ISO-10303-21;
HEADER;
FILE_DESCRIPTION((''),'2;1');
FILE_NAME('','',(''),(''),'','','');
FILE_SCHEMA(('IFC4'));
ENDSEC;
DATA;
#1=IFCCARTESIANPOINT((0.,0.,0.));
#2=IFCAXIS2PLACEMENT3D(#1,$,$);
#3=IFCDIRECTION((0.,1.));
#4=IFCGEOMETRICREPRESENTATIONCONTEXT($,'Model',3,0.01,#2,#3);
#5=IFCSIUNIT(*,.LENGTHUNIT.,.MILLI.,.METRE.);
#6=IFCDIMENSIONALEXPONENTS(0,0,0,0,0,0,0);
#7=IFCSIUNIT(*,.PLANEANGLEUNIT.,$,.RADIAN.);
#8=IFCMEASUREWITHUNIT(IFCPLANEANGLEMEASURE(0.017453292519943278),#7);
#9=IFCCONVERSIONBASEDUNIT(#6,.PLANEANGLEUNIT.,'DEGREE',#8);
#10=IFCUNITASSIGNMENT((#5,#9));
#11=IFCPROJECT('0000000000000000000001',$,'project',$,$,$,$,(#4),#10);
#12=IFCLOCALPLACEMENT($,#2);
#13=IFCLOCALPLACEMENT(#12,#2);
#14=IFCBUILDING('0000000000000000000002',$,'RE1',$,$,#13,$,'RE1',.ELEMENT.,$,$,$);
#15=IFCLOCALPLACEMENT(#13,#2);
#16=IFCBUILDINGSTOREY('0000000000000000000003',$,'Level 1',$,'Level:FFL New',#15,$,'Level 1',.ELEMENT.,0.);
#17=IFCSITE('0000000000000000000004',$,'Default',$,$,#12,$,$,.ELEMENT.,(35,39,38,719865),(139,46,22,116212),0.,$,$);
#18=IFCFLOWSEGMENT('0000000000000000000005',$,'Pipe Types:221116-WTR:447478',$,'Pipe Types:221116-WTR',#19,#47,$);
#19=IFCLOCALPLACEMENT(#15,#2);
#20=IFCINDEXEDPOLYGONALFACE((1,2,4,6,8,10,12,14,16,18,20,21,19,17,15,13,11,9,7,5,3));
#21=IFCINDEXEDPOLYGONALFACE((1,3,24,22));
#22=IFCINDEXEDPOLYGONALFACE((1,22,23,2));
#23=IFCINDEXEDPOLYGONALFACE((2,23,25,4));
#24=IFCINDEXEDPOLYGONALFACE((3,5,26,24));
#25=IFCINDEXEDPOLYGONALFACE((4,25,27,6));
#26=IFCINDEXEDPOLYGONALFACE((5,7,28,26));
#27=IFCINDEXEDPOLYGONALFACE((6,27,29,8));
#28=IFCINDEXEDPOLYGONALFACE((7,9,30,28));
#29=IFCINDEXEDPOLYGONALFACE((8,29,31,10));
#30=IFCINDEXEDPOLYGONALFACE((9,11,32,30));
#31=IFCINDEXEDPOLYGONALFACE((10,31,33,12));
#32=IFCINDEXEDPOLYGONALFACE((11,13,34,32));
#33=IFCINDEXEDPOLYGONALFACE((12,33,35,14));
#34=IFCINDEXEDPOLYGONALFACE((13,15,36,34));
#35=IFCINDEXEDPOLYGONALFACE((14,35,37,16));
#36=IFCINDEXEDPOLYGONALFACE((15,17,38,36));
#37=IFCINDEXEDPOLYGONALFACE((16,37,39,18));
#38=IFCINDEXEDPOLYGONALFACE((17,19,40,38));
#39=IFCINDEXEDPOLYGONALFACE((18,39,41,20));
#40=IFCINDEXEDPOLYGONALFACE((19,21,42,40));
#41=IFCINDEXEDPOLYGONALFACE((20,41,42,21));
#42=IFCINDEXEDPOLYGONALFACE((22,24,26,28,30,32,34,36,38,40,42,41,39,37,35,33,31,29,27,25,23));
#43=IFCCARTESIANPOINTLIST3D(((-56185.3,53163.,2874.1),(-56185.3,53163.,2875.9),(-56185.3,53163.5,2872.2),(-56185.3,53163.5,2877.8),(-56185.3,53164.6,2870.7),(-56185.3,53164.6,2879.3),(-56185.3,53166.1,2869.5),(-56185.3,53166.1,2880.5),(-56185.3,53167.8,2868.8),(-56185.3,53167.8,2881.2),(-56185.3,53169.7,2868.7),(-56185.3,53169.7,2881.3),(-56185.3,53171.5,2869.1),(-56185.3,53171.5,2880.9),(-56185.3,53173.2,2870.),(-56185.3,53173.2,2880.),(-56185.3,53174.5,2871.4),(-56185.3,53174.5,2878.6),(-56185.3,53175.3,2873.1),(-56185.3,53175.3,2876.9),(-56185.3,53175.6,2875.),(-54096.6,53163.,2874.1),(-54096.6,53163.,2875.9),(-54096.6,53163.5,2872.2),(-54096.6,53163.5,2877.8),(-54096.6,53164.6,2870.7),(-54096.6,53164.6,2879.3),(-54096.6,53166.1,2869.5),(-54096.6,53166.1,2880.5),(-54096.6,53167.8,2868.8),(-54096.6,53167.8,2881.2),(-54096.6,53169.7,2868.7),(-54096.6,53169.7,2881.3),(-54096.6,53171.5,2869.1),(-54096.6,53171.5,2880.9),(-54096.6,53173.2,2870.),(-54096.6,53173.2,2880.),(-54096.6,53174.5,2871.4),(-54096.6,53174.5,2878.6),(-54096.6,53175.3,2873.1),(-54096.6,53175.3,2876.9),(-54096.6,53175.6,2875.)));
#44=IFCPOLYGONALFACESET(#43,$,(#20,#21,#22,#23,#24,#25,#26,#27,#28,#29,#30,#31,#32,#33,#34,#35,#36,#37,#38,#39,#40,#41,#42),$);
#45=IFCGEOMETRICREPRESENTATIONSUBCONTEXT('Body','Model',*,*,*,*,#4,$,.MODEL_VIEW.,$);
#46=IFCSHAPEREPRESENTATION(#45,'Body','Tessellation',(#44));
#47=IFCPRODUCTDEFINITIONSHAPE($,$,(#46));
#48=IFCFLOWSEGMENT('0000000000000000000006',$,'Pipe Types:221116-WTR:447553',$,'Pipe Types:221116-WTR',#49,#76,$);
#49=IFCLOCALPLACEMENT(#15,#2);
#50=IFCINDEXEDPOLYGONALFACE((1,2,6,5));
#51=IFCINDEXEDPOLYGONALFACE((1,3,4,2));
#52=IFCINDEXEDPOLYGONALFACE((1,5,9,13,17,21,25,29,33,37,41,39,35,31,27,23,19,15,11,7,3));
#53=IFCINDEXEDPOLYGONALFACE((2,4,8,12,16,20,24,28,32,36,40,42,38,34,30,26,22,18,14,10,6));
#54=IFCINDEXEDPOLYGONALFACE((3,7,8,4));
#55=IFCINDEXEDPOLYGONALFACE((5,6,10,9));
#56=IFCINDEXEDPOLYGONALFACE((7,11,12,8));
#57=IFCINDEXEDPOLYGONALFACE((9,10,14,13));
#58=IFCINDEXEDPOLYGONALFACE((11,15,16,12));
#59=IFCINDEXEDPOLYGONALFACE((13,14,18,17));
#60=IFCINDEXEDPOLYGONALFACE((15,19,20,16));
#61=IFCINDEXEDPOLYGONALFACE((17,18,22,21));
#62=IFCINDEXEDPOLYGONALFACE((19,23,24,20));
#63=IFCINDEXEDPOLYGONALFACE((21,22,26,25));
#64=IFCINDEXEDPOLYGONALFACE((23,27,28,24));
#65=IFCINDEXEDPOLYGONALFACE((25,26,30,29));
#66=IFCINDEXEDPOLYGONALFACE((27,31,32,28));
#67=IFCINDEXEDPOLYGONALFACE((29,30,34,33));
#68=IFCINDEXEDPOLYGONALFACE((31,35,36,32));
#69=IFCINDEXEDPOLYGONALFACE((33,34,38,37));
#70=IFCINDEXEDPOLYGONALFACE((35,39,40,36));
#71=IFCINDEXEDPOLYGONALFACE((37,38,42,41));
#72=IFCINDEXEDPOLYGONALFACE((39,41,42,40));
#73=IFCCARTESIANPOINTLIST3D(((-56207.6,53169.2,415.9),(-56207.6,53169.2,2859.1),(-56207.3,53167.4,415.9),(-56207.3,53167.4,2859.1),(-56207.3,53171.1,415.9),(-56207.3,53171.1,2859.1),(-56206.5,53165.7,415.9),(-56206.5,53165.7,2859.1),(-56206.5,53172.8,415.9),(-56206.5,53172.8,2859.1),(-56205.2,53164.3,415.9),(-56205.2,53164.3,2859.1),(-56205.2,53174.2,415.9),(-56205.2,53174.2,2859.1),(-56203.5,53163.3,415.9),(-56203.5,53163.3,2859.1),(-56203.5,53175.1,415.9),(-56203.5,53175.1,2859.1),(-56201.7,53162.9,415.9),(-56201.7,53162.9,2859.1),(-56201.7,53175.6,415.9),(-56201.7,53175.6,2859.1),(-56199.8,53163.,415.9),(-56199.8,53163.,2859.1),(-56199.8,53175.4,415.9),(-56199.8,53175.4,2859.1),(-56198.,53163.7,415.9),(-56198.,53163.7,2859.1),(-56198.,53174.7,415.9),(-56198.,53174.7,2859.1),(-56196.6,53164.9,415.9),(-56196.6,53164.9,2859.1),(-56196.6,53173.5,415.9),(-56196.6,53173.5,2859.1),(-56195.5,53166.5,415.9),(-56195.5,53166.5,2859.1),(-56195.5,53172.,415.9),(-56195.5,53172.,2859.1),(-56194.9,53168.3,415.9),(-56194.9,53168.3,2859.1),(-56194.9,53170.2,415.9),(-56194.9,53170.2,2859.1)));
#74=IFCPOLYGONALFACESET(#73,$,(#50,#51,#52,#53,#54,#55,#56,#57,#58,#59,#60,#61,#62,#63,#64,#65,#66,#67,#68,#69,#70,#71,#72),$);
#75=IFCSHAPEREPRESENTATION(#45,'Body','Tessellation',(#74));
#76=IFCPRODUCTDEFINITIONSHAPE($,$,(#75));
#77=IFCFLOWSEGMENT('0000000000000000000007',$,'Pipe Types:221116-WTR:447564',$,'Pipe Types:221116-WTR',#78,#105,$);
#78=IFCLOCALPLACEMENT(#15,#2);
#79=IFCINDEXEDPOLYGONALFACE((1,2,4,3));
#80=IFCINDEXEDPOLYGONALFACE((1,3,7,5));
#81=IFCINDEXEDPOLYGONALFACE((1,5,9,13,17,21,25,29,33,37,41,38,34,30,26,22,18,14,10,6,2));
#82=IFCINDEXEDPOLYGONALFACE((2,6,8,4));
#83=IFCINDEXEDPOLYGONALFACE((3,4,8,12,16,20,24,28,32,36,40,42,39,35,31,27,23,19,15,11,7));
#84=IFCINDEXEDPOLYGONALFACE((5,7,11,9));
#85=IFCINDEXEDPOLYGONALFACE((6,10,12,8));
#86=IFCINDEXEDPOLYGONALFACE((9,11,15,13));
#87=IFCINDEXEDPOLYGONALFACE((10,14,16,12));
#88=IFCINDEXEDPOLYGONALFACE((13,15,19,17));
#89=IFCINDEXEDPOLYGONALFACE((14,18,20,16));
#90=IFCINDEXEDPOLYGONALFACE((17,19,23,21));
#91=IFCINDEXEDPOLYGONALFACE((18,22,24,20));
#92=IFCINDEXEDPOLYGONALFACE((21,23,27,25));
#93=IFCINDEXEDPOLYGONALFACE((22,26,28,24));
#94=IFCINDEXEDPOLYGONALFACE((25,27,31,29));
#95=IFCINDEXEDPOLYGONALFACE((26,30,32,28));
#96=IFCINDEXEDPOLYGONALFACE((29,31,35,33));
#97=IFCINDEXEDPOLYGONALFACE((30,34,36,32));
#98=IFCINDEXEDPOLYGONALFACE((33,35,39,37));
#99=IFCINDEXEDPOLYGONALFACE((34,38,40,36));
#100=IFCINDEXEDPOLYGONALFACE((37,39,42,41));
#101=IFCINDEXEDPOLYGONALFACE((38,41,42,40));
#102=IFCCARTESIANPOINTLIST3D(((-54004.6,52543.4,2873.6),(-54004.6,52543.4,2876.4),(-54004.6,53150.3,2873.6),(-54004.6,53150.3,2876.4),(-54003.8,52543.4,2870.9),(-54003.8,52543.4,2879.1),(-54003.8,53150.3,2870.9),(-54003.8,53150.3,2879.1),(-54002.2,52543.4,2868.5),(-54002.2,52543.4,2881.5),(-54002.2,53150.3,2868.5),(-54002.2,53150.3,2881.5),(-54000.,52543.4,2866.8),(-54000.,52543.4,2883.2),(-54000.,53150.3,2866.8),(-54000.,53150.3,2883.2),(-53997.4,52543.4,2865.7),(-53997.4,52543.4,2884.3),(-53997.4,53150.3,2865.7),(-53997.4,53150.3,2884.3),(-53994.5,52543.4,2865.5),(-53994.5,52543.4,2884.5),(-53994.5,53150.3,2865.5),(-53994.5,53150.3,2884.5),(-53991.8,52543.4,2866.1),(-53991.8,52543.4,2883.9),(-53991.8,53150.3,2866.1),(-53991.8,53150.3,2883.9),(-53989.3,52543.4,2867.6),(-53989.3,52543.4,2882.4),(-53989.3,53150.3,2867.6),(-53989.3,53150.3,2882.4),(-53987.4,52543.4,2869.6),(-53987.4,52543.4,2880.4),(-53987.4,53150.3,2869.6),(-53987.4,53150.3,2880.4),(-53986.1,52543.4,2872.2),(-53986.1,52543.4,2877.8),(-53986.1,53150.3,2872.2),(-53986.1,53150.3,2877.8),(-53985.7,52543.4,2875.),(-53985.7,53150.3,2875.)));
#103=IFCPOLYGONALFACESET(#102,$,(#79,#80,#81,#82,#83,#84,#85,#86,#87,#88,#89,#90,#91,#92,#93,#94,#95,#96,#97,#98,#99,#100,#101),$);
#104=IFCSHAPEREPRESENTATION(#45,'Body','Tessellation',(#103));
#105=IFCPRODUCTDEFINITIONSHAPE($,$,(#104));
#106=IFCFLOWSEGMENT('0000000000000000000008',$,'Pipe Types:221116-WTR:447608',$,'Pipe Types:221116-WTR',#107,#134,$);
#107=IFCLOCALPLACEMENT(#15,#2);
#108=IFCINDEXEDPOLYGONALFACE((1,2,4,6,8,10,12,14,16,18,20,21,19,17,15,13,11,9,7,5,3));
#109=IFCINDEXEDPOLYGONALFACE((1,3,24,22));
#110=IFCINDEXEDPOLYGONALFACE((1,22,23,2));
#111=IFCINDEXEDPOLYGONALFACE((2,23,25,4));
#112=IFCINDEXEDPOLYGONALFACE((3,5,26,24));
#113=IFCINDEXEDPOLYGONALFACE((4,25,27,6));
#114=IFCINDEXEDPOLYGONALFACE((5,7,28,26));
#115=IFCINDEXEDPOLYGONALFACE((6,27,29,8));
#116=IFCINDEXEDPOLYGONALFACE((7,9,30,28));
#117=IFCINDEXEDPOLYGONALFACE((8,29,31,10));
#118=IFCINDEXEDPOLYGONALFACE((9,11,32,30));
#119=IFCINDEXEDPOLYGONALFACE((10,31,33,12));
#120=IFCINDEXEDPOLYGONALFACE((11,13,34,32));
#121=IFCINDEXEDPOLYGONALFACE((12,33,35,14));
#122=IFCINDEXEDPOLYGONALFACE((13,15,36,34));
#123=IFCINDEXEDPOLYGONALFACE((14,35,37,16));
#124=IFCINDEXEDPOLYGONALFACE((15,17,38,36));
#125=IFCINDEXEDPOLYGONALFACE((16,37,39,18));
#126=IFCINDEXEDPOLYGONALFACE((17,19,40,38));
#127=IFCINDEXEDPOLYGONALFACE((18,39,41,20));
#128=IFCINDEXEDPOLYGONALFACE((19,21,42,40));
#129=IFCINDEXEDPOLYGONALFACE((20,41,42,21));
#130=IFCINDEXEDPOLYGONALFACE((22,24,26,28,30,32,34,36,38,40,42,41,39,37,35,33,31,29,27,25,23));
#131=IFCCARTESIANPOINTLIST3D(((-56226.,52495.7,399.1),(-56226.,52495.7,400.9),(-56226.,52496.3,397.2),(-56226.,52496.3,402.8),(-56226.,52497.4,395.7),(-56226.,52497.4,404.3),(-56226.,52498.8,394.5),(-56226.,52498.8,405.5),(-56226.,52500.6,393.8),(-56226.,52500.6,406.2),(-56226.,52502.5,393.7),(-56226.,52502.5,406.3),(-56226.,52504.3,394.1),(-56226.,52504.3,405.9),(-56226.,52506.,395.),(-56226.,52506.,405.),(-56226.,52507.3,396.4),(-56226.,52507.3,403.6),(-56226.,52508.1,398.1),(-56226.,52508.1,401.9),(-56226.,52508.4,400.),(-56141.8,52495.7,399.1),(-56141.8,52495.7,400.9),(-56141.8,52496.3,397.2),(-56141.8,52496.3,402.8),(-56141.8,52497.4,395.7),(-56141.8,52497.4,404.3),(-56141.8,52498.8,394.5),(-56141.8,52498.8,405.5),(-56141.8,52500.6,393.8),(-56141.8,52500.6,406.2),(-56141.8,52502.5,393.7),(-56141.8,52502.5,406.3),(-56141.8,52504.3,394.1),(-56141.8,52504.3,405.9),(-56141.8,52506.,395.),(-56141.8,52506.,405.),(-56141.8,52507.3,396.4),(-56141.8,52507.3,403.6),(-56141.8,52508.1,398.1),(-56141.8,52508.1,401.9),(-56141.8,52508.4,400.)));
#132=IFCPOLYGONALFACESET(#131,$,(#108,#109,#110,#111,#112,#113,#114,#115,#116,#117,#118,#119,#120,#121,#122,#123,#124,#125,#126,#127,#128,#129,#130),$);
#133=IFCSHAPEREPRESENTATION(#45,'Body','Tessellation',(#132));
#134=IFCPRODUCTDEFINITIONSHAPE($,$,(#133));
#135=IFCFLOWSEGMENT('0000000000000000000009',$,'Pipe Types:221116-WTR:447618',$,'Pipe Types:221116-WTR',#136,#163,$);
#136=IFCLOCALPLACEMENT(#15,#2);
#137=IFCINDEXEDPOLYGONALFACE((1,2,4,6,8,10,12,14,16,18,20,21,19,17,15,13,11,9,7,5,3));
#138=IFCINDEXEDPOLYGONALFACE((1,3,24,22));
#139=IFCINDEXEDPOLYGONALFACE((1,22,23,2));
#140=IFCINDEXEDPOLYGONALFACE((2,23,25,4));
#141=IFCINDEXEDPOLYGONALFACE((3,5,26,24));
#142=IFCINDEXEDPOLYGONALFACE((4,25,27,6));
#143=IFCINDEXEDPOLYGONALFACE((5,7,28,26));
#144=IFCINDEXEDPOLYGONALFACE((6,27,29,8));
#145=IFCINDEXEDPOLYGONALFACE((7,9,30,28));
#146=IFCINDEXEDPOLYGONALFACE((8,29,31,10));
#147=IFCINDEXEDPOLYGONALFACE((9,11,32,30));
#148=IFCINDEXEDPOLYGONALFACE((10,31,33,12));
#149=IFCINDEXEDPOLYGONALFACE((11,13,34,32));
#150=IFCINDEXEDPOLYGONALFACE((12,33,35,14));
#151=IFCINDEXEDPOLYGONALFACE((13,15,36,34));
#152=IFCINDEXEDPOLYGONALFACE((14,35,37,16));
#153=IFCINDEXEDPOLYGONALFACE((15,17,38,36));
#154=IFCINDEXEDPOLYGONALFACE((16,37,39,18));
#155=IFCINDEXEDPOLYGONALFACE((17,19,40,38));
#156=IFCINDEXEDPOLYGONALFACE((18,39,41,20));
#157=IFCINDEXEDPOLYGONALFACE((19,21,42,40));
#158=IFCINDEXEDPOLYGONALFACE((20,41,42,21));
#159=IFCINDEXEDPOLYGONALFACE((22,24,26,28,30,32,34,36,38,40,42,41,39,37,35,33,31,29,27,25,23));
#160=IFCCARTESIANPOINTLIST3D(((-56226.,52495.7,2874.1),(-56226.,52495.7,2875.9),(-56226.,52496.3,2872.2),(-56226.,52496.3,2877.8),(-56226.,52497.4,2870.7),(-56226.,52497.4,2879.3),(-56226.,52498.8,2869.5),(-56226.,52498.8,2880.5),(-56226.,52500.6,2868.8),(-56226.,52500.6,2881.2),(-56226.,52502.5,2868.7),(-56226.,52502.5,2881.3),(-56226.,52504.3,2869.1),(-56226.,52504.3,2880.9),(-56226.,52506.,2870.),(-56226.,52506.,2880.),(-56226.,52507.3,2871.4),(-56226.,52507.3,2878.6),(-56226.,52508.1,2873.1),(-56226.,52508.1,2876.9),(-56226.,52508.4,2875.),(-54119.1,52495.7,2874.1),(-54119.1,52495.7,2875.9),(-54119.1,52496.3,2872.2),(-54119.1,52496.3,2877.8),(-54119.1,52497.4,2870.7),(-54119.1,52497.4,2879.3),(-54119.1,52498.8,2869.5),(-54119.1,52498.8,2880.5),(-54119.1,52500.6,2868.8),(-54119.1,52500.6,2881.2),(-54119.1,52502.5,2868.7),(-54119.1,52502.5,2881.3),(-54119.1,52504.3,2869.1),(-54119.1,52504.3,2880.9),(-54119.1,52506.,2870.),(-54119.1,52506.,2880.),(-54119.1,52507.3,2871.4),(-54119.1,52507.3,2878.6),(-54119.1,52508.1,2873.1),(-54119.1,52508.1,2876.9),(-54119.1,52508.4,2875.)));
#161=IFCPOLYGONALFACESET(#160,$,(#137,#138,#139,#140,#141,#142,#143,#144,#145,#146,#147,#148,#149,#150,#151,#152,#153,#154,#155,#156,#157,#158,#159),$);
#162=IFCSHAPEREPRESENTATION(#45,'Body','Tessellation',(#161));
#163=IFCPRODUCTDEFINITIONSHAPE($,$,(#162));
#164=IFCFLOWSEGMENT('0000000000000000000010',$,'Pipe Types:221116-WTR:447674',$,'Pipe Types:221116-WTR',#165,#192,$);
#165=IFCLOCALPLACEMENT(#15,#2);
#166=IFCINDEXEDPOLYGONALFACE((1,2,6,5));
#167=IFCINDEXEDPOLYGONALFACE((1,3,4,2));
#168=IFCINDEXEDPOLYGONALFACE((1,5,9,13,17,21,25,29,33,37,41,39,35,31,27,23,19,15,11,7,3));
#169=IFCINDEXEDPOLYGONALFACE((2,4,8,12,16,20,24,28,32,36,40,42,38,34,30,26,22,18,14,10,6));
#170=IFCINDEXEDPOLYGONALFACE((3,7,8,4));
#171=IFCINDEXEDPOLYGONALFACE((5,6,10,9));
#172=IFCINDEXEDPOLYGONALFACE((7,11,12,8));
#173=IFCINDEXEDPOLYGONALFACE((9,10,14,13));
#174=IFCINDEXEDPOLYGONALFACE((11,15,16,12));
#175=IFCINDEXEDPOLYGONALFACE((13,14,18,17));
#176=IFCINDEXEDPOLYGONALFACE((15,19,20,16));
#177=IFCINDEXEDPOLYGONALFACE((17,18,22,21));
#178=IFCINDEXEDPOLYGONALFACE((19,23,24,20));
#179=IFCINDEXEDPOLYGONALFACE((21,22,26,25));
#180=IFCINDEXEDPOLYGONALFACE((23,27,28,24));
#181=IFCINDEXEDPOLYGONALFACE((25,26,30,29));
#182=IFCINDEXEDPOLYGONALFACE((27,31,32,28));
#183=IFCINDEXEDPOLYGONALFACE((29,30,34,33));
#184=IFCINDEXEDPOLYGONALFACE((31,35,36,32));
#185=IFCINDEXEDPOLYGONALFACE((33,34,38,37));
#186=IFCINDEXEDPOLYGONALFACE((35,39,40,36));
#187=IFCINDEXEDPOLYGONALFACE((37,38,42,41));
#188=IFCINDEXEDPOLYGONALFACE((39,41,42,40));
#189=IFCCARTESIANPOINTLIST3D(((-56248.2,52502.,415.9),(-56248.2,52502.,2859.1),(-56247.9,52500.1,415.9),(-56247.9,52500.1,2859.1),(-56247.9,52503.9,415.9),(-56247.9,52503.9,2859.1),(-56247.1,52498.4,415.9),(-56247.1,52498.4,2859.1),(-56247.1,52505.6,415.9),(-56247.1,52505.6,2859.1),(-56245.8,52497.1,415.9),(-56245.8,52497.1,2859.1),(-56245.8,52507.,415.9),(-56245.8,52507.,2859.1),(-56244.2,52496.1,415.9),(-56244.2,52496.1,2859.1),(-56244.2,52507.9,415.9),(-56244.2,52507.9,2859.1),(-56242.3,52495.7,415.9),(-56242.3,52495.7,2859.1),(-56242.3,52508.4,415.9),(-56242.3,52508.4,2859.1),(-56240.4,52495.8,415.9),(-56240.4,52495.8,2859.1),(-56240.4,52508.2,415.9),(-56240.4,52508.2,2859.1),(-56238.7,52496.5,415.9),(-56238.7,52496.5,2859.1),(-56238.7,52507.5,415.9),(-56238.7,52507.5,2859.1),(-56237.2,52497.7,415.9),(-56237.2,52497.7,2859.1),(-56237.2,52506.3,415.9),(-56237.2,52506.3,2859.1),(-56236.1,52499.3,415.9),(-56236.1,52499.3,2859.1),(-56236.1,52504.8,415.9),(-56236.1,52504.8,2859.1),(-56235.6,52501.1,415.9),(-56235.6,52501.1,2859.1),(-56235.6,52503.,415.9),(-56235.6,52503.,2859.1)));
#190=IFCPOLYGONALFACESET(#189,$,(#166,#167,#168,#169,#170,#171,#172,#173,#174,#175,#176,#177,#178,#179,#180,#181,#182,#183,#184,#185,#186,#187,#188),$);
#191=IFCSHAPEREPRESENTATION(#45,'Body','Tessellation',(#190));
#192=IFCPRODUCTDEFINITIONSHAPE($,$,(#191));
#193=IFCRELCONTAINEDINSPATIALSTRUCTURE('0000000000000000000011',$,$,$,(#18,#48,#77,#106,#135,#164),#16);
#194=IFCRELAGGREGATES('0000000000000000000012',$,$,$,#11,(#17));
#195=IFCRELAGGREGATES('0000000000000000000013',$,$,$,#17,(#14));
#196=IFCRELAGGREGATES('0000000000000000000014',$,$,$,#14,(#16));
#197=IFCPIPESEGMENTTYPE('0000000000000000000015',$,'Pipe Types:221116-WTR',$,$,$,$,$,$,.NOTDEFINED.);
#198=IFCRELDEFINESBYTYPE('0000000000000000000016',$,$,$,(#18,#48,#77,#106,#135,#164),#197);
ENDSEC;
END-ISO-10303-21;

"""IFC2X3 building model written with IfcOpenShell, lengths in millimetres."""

from ifc_helpers import new_model, entity, si_unit, converted_unit, direction, frame, frame_2d, origin, origin_2d_with_axis, place, context, subcontext, project, spatial, circle, extrude, type_object, element, save


model = new_model("IFC2X3")

# Units and contexts
model_context = context("Model", 3, precision=0.01, world=origin(), true_north=direction((0.0, 1.0)))
body_context = subcontext(model_context, "Body", "Model", "MODEL_VIEW")
ifc_project = project(units=[si_unit("LENGTHUNIT", "METRE", prefix="MILLI"), converted_unit("PLANEANGLEUNIT", "DEGREE", entity("IfcPlaneAngleMeasure", 0.017453292519943278), si_unit("PLANEANGLEUNIT", "RADIAN"), dimensions=[0, 0, 0, 0, 0, 0, 0])], contexts=[model_context])

# Site, building, storey
site_placement = place(None, origin())
site = spatial("IfcSite", under=ifc_project, at=site_placement, Name="Default", CompositionType="ELEMENT", RefLatitude=(35, 39, 38, 719865), RefLongitude=(139, 46, 22, 116212), RefElevation=0.0)
building_placement = place(site_placement, origin())
building = spatial("IfcBuilding", under=site, at=building_placement, Name="RE1", LongName="RE1", CompositionType="ELEMENT")
storey_placement = place(building_placement, origin())
storey = spatial("IfcBuildingStorey", under=building, at=storey_placement, Name="Level 1", ObjectType="Level:FFL New", LongName="Level 1", CompositionType="ELEMENT", Elevation=0.0)

# Flow segments
pipe_segment_type_1 = type_object("IfcPipeSegmentType", Name="Pipe Types:221116-WTR", PredefinedType="NOTDEFINED")
flow_segment_1_placement = place(storey_placement, origin())
element("IfcFlowSegment", 1, at=flow_segment_1_placement, inside=storey, type_object=pipe_segment_type_1, Name="Pipe Types:221116-WTR:447478", ObjectType="Pipe Types:221116-WTR", context=body_context, shape_type="SweptSolid", body=[
    extrude(circle(Radius=6.3, at=frame_2d((0.0, 0.0), x_axis=(1.0, 0.0))), frame((-56185.3, 53169.2, 2875.0), z_axis=(1.0, 0.0, 0.0), x_axis=(0.0, 1.0, 0.0)), (0.0, 0.0, 1.0), 2088.7),
])
flow_segment_2_placement = place(storey_placement, origin())
element("IfcFlowSegment", 2, at=flow_segment_2_placement, inside=storey, type_object=pipe_segment_type_1, Name="Pipe Types:221116-WTR:447553", ObjectType="Pipe Types:221116-WTR", context=body_context, shape_type="SweptSolid", body=[
    extrude(circle(Radius=6.3, at=origin_2d_with_axis()), frame((-56201.2, 53169.2, 415.9), z_axis=(0.0, 0.0, 1.0), x_axis=(-1.0, 0.0, 0.0)), (0.0, 0.0, 1.0), 2443.2),
])
flow_segment_3_placement = place(storey_placement, origin())
element("IfcFlowSegment", 3, at=flow_segment_3_placement, inside=storey, type_object=pipe_segment_type_1, Name="Pipe Types:221116-WTR:447564", ObjectType="Pipe Types:221116-WTR", context=body_context, shape_type="SweptSolid", body=[
    extrude(circle(Radius=9.5, at=origin_2d_with_axis()), frame((-53995.2, 52543.4, 2875.0), z_axis=(0.0, 1.0, 0.0), x_axis=(1.0, 0.0, 0.0)), (0.0, 0.0, 1.0), 606.9),
])
flow_segment_4_placement = place(storey_placement, origin())
element("IfcFlowSegment", 4, at=flow_segment_4_placement, inside=storey, type_object=pipe_segment_type_1, Name="Pipe Types:221116-WTR:447608", ObjectType="Pipe Types:221116-WTR", context=body_context, shape_type="SweptSolid", body=[
    extrude(circle(Radius=6.3, at=frame_2d((0.0, 0.0), x_axis=(1.0, 0.0))), frame((-56226.0, 52502.0, 400.0), z_axis=(1.0, 0.0, 0.0), x_axis=(0.0, 1.0, 0.0)), (0.0, 0.0, 1.0), 84.1),
])
flow_segment_5_placement = place(storey_placement, origin())
element("IfcFlowSegment", 5, at=flow_segment_5_placement, inside=storey, type_object=pipe_segment_type_1, Name="Pipe Types:221116-WTR:447618", ObjectType="Pipe Types:221116-WTR", context=body_context, shape_type="SweptSolid", body=[
    extrude(circle(Radius=6.3, at=frame_2d((0.0, 0.0), x_axis=(1.0, 0.0))), frame((-56226.0, 52502.0, 2875.0), z_axis=(1.0, 0.0, 0.0), x_axis=(0.0, 1.0, 0.0)), (0.0, 0.0, 1.0), 2106.9),
])
flow_segment_6_placement = place(storey_placement, origin())
element("IfcFlowSegment", 6, at=flow_segment_6_placement, inside=storey, type_object=pipe_segment_type_1, Name="Pipe Types:221116-WTR:447674", ObjectType="Pipe Types:221116-WTR", context=body_context, shape_type="SweptSolid", body=[
    extrude(circle(Radius=6.3, at=origin_2d_with_axis()), frame((-56241.8, 52502.0, 415.9), z_axis=(0.0, 0.0, 1.0), x_axis=(-1.0, 0.0, 0.0)), (0.0, 0.0, 1.0), 2443.2),
])

save(model, "model.ifc")
